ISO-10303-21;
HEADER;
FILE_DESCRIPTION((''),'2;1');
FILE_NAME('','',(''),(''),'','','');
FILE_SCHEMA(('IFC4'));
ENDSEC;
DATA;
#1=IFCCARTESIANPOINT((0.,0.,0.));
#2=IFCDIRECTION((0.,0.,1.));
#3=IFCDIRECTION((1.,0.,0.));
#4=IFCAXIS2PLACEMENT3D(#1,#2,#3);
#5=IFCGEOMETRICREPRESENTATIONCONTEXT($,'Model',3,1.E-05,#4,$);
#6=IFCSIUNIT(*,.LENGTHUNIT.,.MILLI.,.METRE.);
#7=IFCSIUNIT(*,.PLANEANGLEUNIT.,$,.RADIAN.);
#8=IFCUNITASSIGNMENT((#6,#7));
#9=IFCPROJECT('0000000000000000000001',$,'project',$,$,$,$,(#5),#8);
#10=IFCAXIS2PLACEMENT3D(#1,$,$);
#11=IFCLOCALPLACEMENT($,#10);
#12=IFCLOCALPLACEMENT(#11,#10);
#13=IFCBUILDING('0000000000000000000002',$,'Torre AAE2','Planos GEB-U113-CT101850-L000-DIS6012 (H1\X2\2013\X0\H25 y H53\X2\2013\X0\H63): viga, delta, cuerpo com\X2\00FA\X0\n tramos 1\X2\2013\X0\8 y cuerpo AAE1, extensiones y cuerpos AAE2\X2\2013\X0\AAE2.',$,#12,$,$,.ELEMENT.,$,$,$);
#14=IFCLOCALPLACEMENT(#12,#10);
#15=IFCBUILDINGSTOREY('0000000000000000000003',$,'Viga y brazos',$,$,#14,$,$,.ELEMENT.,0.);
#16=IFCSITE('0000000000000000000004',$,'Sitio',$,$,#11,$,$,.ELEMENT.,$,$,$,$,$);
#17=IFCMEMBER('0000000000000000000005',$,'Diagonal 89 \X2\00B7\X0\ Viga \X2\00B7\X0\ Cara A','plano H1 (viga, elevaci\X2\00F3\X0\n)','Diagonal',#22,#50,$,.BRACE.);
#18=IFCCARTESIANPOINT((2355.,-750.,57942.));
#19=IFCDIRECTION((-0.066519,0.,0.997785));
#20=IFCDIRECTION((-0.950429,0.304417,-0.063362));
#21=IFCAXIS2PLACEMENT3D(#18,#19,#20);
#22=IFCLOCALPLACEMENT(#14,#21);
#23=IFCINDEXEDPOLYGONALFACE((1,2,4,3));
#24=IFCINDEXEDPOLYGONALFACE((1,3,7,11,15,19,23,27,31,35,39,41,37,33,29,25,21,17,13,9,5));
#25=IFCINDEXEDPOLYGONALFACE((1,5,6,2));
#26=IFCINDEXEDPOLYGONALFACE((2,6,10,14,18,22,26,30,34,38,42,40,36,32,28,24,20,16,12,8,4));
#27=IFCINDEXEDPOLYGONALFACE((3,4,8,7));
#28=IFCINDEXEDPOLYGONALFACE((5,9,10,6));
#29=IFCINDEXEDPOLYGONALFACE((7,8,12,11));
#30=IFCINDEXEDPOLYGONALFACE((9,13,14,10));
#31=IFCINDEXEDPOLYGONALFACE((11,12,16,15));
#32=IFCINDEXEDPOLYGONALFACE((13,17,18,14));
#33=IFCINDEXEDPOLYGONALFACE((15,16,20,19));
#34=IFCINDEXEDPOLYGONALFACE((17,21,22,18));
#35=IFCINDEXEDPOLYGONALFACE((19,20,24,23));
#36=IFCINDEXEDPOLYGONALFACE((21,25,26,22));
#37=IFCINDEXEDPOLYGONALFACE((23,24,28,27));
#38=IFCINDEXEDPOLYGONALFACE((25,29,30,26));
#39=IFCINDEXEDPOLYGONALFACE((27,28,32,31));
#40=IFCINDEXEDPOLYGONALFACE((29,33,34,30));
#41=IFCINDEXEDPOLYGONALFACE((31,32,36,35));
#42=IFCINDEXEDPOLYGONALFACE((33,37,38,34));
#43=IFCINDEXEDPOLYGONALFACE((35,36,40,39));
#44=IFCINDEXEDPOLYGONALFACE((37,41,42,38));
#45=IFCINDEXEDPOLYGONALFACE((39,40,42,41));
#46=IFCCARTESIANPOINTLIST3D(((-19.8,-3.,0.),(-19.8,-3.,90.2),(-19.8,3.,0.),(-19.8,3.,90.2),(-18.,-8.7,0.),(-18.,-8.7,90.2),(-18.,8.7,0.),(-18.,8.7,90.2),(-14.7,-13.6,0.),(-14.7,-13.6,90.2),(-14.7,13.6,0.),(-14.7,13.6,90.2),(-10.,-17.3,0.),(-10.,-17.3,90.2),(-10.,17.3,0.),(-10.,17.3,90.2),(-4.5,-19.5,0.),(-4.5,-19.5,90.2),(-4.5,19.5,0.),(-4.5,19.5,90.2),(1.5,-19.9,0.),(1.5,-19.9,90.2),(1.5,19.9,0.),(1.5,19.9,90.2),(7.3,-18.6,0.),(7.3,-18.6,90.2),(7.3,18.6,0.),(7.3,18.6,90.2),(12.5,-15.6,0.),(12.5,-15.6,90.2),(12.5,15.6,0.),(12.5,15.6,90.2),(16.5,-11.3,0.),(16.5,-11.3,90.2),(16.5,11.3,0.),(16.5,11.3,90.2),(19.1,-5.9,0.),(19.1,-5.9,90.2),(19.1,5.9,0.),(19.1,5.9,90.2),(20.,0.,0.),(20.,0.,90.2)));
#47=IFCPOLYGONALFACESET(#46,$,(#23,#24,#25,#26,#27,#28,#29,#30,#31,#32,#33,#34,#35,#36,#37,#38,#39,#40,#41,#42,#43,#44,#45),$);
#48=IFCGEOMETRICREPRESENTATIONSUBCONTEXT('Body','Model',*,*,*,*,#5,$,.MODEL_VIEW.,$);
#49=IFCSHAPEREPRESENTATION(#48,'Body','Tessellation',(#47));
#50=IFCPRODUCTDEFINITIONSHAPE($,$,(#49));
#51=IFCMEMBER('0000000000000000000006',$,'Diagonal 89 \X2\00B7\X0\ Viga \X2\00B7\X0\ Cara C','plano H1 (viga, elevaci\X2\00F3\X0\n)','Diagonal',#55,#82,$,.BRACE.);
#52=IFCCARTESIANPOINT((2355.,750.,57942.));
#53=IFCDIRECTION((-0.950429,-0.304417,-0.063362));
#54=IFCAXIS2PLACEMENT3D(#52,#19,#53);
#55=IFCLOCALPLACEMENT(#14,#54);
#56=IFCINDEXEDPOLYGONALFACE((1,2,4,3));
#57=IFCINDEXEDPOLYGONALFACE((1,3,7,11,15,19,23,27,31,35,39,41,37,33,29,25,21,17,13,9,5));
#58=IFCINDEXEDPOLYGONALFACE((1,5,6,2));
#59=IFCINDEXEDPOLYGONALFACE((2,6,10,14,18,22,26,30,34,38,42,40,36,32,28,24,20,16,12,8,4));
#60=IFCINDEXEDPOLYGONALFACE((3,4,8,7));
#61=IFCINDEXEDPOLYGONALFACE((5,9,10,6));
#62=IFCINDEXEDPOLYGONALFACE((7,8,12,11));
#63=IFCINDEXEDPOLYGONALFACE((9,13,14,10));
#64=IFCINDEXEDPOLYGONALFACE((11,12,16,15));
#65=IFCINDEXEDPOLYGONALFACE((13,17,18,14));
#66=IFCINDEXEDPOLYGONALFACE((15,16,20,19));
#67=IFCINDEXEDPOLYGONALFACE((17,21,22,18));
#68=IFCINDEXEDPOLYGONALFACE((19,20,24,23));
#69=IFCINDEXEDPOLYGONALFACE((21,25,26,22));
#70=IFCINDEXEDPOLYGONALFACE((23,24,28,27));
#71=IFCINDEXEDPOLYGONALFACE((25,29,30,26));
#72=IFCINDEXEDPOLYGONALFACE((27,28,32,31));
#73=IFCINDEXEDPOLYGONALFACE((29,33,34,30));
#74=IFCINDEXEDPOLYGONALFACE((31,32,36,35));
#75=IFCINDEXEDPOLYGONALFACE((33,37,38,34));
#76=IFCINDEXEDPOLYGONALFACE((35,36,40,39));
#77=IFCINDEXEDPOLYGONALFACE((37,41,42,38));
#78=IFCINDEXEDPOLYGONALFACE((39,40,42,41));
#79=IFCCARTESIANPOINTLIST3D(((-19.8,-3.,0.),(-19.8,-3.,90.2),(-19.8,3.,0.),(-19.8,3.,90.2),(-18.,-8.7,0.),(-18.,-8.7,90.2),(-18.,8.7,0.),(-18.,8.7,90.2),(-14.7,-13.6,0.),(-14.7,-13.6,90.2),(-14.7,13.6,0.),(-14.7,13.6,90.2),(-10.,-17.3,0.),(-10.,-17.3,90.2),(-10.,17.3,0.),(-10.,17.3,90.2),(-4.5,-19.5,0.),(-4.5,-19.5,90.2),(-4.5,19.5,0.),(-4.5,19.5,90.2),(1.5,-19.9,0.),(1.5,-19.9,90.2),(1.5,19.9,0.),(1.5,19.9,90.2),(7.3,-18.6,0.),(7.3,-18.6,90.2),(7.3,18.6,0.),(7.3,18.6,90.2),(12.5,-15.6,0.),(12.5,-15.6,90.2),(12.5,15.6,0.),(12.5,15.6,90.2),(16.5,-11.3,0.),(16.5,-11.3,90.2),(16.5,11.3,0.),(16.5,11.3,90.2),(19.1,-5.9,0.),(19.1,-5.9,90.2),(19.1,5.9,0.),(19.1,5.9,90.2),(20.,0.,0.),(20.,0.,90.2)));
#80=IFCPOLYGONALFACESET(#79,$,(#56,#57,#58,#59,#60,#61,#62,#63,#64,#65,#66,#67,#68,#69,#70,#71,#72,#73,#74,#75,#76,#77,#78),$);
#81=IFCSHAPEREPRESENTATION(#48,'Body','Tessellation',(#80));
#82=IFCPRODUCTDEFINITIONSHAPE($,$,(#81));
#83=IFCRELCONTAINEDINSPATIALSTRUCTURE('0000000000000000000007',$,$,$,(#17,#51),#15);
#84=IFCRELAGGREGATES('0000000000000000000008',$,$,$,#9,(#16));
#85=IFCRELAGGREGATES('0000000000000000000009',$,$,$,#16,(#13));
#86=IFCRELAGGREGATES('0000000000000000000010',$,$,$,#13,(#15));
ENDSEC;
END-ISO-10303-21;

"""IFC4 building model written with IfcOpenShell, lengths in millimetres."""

from ifc_helpers import new_model, si_unit, frame, origin, origin_with_axes, place, context, subcontext, project, spatial, circle, extrude, element, save


model = new_model("IFC4")

# Units and contexts
model_context = context("Model", 3, precision=1e-05, world=origin_with_axes())
body_context = subcontext(model_context, "Body", "Model", "MODEL_VIEW")
ifc_project = project(units=[si_unit("LENGTHUNIT", "METRE", prefix="MILLI"), si_unit("PLANEANGLEUNIT", "RADIAN")], contexts=[model_context])

# Site, building, storey
site_placement = place(None, origin())
site = spatial("IfcSite", under=ifc_project, at=site_placement, Name="Sitio", CompositionType="ELEMENT")
building_placement = place(site_placement, origin())
building = spatial("IfcBuilding", under=site, at=building_placement, Name="Torre AAE2", Description="Planos GEB-U113-CT101850-L000-DIS6012 (H1–H25 y H53–H63): viga, delta, cuerpo común tramos 1–8 y cuerpo AAE1, extensiones y cuerpos AAE2–AAE2.", CompositionType="ELEMENT")
storey_placement = place(building_placement, origin())
storey = spatial("IfcBuildingStorey", under=building, at=storey_placement, Name="Viga y brazos", CompositionType="ELEMENT", Elevation=0.0)

# Members
for number, where, z_axis, x_axis, name in (
    (1, (2355.0, -750.0, 57942.0), (-0.066519, 0.0, 0.997785), (-0.950429, 0.304417, -0.063362), "Diagonal 89 · Viga · Cara A"),
    (2, (2355.0, 750.0, 57942.0), (-0.066519, 0.0, 0.997785), (-0.950429, -0.304417, -0.063362), "Diagonal 89 · Viga · Cara C"),
):
    element("IfcMember", number, at=place(storey_placement, frame(where, z_axis=z_axis, x_axis=x_axis)), inside=storey, Name=name, Description="plano H1 (viga, elevación)", ObjectType="Diagonal", PredefinedType="BRACE", context=body_context, shape_type="SweptSolid", body=[
        extrude(circle(Radius=20.0), None, (0.0, 0.0, 1.0), 90.2),
    ])

save(model, "model.ifc")
